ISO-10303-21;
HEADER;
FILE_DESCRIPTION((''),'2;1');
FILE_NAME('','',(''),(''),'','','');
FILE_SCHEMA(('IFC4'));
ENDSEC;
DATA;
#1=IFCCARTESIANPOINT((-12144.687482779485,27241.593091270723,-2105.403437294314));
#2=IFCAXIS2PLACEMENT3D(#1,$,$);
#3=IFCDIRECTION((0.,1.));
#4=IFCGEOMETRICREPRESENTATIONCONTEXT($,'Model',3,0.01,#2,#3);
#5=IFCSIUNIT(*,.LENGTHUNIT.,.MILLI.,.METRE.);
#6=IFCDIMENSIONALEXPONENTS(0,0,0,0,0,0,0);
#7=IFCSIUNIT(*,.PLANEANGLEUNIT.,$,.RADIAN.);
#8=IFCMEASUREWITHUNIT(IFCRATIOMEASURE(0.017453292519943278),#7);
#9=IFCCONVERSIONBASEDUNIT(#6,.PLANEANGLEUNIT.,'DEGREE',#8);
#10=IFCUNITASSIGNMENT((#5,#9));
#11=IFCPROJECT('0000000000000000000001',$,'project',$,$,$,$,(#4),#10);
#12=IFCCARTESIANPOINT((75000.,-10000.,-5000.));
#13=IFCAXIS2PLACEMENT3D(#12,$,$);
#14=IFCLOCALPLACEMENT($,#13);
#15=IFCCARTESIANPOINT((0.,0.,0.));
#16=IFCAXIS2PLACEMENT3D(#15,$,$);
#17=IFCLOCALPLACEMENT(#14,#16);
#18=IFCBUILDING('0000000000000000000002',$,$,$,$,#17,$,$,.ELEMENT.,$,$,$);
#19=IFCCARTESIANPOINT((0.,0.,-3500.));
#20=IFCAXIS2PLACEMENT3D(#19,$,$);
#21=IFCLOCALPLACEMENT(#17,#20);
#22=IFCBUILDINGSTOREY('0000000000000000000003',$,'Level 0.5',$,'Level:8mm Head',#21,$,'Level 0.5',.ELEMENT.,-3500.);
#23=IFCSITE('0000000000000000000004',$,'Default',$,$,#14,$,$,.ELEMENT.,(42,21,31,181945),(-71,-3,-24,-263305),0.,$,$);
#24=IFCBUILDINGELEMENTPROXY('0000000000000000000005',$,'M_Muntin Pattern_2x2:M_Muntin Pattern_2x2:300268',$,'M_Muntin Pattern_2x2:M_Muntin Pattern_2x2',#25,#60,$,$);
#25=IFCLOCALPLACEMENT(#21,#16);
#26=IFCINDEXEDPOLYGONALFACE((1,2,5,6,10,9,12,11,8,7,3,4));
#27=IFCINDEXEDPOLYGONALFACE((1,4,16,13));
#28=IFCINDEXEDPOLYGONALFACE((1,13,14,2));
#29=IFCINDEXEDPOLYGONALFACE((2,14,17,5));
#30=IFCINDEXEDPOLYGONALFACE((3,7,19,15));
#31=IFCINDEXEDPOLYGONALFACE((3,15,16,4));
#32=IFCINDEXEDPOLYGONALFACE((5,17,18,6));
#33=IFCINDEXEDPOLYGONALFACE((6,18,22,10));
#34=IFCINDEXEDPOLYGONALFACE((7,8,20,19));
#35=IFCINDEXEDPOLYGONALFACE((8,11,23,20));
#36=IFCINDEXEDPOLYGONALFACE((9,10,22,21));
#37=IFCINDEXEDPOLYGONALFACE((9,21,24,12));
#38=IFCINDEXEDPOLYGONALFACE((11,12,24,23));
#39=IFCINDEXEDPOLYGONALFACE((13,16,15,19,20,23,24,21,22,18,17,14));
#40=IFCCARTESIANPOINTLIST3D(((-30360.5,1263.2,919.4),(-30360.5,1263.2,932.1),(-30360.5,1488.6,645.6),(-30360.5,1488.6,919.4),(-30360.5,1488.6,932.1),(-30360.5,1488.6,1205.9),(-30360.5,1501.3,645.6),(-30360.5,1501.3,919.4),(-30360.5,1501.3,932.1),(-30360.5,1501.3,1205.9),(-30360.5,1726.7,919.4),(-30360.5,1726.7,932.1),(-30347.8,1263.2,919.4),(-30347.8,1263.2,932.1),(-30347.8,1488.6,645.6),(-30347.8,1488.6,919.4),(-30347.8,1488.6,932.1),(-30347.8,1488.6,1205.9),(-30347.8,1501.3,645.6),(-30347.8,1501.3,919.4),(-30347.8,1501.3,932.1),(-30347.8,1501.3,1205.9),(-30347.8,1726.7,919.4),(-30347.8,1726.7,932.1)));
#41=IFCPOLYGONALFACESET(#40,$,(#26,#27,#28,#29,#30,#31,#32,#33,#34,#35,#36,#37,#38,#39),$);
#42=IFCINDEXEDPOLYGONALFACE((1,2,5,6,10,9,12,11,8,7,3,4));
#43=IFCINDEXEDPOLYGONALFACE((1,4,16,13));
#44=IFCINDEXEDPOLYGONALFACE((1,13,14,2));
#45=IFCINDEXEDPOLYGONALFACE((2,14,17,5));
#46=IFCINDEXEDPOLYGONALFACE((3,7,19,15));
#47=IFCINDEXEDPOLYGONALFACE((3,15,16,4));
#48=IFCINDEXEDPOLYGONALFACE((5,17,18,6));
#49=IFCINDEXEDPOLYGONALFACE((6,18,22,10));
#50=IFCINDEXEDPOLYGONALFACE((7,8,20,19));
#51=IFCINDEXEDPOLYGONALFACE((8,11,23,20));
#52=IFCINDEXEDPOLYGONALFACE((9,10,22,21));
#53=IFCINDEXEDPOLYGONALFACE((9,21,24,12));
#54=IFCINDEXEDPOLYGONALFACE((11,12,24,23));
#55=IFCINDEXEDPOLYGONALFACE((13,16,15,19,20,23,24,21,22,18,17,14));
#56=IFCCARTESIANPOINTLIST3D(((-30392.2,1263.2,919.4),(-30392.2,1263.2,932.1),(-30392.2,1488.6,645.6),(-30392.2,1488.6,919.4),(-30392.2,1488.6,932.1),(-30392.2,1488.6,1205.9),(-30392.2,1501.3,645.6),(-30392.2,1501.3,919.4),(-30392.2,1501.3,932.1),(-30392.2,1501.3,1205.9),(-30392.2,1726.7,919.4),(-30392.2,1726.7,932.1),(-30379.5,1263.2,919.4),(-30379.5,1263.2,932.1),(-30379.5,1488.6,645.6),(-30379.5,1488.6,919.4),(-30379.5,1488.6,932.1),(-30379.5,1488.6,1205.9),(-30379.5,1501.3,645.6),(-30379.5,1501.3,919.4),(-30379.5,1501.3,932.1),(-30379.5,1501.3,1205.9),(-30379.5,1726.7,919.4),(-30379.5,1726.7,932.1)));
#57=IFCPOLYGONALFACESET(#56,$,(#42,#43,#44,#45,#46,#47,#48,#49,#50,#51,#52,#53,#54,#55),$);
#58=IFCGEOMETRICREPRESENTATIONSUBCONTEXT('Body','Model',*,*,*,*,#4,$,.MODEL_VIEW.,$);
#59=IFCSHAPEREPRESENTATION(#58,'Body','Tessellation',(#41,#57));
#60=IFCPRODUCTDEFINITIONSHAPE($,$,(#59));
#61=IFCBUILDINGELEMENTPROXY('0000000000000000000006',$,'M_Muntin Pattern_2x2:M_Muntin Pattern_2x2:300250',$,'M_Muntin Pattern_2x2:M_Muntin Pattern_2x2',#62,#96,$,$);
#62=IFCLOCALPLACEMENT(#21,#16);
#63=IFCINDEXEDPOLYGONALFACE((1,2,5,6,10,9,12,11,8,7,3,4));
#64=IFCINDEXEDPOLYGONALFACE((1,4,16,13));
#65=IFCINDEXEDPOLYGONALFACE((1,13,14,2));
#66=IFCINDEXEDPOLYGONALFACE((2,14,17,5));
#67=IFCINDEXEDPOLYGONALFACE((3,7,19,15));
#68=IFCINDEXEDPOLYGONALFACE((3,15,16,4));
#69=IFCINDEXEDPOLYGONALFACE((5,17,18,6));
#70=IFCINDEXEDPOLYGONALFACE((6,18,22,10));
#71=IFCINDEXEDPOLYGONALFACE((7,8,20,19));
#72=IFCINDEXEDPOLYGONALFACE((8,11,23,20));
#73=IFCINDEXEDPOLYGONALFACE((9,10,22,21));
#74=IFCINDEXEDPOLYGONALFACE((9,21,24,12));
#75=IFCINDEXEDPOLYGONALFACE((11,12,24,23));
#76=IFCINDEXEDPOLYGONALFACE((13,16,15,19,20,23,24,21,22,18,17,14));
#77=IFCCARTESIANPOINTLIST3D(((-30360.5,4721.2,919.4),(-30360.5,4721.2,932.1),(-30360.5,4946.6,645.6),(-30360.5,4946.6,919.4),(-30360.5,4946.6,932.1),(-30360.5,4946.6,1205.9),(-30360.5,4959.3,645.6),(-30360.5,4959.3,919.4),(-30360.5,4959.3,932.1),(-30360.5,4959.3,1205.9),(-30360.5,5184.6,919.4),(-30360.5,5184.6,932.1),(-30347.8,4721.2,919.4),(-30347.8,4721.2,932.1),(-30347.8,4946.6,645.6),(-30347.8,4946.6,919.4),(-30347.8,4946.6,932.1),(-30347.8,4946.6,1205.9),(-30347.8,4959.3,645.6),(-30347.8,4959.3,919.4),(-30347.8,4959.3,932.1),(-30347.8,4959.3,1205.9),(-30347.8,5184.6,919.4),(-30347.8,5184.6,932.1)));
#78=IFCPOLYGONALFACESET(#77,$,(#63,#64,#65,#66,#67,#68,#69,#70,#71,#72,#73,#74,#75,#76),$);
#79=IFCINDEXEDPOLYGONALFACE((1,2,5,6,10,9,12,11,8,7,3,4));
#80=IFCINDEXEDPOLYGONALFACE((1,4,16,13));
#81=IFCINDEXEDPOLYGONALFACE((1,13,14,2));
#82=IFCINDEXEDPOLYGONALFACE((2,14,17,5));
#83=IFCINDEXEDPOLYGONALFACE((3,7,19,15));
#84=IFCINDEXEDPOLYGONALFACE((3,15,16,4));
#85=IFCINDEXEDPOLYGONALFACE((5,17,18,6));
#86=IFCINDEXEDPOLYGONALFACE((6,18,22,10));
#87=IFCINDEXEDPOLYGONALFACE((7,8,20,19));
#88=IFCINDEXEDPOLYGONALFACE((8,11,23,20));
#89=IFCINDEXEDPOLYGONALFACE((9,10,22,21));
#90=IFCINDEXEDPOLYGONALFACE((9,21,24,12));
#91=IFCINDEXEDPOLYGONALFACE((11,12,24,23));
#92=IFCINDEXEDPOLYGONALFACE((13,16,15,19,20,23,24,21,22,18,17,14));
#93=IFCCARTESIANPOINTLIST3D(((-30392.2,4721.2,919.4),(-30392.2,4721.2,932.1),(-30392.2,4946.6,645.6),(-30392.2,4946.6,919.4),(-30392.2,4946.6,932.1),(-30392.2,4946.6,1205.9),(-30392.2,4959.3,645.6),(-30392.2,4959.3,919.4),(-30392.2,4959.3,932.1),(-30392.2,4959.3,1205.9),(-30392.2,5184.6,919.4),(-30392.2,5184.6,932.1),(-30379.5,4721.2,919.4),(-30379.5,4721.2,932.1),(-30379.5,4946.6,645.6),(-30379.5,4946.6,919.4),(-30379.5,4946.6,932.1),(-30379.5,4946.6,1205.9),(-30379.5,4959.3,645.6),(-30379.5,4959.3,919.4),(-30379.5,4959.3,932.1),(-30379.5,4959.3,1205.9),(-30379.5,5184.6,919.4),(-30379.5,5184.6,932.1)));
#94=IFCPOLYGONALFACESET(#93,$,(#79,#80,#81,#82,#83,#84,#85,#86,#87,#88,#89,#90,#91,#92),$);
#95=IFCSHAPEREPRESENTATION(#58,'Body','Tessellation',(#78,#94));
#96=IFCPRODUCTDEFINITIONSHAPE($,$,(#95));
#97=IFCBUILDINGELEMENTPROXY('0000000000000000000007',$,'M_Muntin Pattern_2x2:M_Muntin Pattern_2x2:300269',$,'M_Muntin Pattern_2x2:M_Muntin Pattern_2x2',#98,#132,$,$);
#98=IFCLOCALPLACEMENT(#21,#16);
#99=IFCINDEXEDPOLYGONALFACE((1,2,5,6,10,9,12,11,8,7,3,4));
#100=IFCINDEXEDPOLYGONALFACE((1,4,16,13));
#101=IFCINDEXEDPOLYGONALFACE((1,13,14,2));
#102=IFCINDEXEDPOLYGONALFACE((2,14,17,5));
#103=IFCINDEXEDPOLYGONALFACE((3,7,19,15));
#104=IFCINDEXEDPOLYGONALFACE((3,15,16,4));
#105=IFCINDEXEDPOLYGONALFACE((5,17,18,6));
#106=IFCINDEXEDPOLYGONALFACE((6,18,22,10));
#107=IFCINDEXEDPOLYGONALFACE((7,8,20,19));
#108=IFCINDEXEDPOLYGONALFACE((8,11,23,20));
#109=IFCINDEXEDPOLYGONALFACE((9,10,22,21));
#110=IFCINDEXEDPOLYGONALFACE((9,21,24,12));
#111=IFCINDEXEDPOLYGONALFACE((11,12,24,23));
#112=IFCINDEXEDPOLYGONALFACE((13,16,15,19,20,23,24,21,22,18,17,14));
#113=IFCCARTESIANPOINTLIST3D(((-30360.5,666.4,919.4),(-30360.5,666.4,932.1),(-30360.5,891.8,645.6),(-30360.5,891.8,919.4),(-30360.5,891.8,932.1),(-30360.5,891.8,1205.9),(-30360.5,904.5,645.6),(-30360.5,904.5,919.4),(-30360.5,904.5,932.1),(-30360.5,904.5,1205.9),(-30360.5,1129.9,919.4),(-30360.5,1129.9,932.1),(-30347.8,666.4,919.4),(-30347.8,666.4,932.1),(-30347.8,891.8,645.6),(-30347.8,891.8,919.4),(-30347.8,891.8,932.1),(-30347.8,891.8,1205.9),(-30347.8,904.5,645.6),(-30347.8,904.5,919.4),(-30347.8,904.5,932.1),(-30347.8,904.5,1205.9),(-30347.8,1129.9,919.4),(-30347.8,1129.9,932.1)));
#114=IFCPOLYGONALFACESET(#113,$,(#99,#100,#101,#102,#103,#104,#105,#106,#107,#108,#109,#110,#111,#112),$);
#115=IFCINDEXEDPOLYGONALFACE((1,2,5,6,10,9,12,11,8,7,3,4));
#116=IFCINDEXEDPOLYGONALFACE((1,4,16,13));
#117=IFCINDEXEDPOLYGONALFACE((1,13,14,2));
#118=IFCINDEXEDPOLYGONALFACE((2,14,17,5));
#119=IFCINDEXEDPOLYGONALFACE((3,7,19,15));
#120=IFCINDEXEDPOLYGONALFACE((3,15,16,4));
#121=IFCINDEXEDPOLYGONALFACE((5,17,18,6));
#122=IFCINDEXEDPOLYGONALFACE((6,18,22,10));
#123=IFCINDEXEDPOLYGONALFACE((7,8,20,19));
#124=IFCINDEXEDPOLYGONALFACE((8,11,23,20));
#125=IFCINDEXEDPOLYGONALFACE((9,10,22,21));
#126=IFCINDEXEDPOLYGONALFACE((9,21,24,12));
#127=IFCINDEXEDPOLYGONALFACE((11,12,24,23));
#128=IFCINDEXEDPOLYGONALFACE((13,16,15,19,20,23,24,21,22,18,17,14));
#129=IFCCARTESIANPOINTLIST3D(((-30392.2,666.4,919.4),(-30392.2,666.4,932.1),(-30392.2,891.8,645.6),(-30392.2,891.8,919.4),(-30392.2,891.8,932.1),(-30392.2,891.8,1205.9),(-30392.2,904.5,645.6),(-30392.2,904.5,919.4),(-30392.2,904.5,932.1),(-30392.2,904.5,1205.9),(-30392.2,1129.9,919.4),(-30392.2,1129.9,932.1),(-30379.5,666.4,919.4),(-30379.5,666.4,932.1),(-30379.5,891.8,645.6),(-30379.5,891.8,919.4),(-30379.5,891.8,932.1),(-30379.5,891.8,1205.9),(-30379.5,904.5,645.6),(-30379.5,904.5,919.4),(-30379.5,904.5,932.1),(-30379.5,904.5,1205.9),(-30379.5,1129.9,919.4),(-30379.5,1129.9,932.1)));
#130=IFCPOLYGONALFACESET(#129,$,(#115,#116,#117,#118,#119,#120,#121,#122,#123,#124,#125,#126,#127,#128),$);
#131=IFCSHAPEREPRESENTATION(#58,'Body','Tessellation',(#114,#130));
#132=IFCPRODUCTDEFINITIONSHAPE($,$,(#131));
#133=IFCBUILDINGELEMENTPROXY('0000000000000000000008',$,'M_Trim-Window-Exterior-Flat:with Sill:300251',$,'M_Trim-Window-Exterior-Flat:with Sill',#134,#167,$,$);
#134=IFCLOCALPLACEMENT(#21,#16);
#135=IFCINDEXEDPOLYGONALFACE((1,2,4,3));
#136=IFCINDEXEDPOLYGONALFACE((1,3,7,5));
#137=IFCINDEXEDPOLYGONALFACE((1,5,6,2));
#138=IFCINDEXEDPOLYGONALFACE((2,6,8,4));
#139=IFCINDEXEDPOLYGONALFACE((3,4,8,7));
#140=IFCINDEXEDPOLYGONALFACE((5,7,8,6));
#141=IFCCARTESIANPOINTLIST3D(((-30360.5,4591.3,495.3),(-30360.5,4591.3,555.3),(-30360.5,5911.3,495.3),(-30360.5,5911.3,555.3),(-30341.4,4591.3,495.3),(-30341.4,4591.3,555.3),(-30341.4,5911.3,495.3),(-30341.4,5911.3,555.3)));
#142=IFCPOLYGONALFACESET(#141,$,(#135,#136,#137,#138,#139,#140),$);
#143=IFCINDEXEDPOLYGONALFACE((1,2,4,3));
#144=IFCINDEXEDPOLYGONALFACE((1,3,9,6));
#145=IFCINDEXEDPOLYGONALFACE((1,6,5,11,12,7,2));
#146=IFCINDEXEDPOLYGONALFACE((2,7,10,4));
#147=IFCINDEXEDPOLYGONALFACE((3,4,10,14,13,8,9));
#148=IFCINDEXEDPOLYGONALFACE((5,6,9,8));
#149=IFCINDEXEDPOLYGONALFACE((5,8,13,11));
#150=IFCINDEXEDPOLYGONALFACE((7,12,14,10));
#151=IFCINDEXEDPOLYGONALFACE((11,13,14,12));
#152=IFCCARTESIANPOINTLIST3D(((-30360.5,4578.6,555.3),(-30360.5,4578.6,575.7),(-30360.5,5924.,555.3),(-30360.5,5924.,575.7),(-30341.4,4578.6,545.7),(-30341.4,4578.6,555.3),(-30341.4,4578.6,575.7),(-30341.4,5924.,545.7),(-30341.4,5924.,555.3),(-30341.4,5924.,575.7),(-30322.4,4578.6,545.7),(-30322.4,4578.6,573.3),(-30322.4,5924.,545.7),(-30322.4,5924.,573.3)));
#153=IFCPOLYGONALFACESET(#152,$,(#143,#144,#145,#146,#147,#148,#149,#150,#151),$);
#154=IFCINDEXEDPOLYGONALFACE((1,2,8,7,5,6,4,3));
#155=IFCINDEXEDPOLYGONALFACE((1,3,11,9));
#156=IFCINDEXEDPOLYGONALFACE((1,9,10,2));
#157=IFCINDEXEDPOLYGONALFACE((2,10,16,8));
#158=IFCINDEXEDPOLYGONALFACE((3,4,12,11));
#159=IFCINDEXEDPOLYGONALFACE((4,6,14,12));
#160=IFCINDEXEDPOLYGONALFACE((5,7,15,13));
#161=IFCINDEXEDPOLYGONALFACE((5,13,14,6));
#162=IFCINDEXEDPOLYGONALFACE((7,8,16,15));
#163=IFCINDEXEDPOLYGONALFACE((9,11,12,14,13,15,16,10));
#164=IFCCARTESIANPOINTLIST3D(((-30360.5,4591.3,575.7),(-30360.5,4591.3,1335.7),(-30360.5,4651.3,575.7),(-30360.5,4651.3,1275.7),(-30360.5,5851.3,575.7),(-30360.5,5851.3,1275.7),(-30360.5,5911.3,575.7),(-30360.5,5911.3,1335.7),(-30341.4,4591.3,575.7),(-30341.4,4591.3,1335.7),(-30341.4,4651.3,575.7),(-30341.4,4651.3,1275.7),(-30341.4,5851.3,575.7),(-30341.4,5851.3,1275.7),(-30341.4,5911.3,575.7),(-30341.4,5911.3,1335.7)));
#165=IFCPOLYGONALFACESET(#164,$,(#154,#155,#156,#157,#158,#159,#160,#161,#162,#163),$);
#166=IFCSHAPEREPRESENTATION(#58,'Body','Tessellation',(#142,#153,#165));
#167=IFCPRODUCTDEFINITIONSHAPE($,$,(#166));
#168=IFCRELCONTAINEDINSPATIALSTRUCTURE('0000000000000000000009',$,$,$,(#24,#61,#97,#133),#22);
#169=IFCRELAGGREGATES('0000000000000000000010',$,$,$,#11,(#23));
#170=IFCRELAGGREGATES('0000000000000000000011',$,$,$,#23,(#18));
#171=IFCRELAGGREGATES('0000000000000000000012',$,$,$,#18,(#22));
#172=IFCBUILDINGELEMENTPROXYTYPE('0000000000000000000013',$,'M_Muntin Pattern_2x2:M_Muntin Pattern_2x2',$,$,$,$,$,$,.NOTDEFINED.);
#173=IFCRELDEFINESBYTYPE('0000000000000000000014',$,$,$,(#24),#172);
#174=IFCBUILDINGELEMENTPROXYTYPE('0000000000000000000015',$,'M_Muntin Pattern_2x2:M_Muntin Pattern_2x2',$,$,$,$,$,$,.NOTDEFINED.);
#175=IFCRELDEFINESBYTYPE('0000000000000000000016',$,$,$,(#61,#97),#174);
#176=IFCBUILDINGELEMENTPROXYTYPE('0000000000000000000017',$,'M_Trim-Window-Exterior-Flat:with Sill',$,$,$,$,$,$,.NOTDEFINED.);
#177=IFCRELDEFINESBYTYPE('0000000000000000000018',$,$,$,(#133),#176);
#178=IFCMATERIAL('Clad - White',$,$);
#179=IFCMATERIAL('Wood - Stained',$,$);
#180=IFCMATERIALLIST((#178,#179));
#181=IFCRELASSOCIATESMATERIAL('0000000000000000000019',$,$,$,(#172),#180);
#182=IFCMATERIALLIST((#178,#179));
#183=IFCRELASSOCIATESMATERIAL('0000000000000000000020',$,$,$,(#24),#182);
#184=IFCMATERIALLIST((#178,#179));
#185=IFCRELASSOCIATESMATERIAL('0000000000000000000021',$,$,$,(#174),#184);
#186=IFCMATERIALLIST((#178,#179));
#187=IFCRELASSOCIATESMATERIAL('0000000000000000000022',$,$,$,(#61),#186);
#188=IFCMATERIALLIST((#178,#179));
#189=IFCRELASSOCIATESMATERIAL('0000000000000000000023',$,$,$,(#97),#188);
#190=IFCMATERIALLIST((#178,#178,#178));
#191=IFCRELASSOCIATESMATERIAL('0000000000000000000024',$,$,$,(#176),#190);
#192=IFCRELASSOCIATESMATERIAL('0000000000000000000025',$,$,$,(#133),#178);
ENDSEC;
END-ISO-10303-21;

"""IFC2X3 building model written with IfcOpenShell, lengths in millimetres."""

from ifc_helpers import new_model, entity, si_unit, converted_unit, direction, frame, frame_2d, origin, place, context, subcontext, project, spatial, polyline, rectangle, outline, extrude, source, transform, mapped, material, material_list, type_object, type_shapes, element, save


model = new_model("IFC2X3")

# Units and contexts
model_context = context("Model", 3, precision=0.01, world=frame((-12144.687482779485, 27241.593091270723, -2105.403437294314)), true_north=direction((0.0, 1.0)))
body_context = subcontext(model_context, "Body", "Model", "MODEL_VIEW")
ifc_project = project(units=[si_unit("LENGTHUNIT", "METRE", prefix="MILLI"), converted_unit("PLANEANGLEUNIT", "DEGREE", entity("IfcRatioMeasure", 0.017453292519943278), si_unit("PLANEANGLEUNIT", "RADIAN"), dimensions=[0, 0, 0, 0, 0, 0, 0])], contexts=[model_context])

# Site, building, storey
site_placement = place(None, frame((75000.0, -10000.0, -5000.0)))
site = spatial("IfcSite", under=ifc_project, at=site_placement, Name="Default", CompositionType="ELEMENT", RefLatitude=(42, 21, 31, 181945), RefLongitude=(-71, -3, -24, -263305), RefElevation=0.0)
building_placement = place(site_placement, origin())
building = spatial("IfcBuilding", under=site, at=building_placement, CompositionType="ELEMENT")
storey_placement = place(building_placement, frame((0.0, 0.0, -3500.0)))
storey = spatial("IfcBuildingStorey", under=building, at=storey_placement, Name="Level 0.5", ObjectType="Level:8mm Head", LongName="Level 0.5", CompositionType="ELEMENT", Elevation=-3500.0)

# Building element proxies
ifc_material_1 = material(Name="Clad - White")
ifc_material_2 = material(Name="Wood - Stained")
ifc_material_list_1 = material_list([ifc_material_1, ifc_material_2])
ifc_material_list_2 = material_list([ifc_material_1, ifc_material_2])
building_element_proxy_type_1 = type_object("IfcBuildingElementProxyType", Name="M_Muntin Pattern_2x2:M_Muntin Pattern_2x2", PredefinedType="NOTDEFINED", material=ifc_material_list_2)
shared_shape_1 = source(origin(), body_context, "Body", "SweptSolid", [
    extrude(outline(polyline([(6.4, -6.4), (280.1, -6.4), (280.1, 6.3), (6.4, 6.3), (6.4, 231.7), (-6.3, 231.7), (-6.3, 6.3), (-280.2, 6.3), (-280.2, -6.4), (-6.3, -6.4), (-6.3, -231.7), (6.4, -231.7), (6.4, -6.4)])), frame((0.0, 9.5, 280.1), z_axis=(0.0, 1.0, 0.0), x_axis=(0.0, 0.0, 1.0)), (0.0, 0.0, 1.0), 12.7),
    extrude(outline(polyline([(6.4, -6.4), (280.2, -6.4), (280.2, 6.3), (6.4, 6.3), (6.4, 231.7), (-6.3, 231.7), (-6.3, 6.3), (-280.2, 6.3), (-280.2, -6.4), (-6.3, -6.4), (-6.3, -231.7), (6.4, -231.7), (6.4, -6.4)])), frame((0.0, -22.2, 280.2), z_axis=(0.0, 1.0, 0.0), x_axis=(0.0, 0.0, 1.0)), (0.0, 0.0, 1.0), 12.7),
])
type_shapes(building_element_proxy_type_1, [shared_shape_1])
proxy_1_placement = place(storey_placement, frame((-30370.0, 1495.0, 645.6), z_axis=(0.0, 0.0, 1.0), x_axis=(0.0, -1.0, 0.0)))
element("IfcBuildingElementProxy", 1, at=proxy_1_placement, inside=storey, type_object=building_element_proxy_type_1, material=ifc_material_list_1, Name="M_Muntin Pattern_2x2:M_Muntin Pattern_2x2:300268", ObjectType="M_Muntin Pattern_2x2:M_Muntin Pattern_2x2", context=body_context, shape_type="MappedRepresentation", body=[
    mapped(shared_shape_1, transform((0.0, 0.0, 0.0), scale=1.0)),
])
ifc_material_list_3 = material_list([ifc_material_1, ifc_material_2])
ifc_material_list_4 = material_list([ifc_material_1, ifc_material_2])
building_element_proxy_type_2 = type_object("IfcBuildingElementProxyType", Name="M_Muntin Pattern_2x2:M_Muntin Pattern_2x2", PredefinedType="NOTDEFINED", material=ifc_material_list_4)
shared_shape_2 = source(origin(), body_context, "Body", "SweptSolid", [
    extrude(outline(polyline([(6.4, -6.4), (280.1, -6.4), (280.1, 6.3), (6.4, 6.3), (6.4, 231.7), (-6.3, 231.7), (-6.3, 6.3), (-280.2, 6.3), (-280.2, -6.4), (-6.3, -6.4), (-6.3, -231.7), (6.4, -231.7), (6.4, -6.4)])), frame((0.0, -22.2, 280.1), z_axis=(0.0, 1.0, 0.0), x_axis=(0.0, 0.0, 1.0)), (0.0, 0.0, 1.0), 12.7),
    extrude(outline(polyline([(6.4, -6.4), (280.2, -6.4), (280.2, 6.3), (6.4, 6.3), (6.4, 231.7), (-6.3, 231.7), (-6.3, 6.3), (-280.2, 6.3), (-280.2, -6.4), (-6.3, -6.4), (-6.3, -231.7), (6.4, -231.7), (6.4, -6.4)])), frame((0.0, 9.5, 280.2), z_axis=(0.0, 1.0, 0.0), x_axis=(0.0, 0.0, 1.0)), (0.0, 0.0, 1.0), 12.7),
])
type_shapes(building_element_proxy_type_2, [shared_shape_2])
proxy_2_placement = place(storey_placement, frame((-30370.0, 4952.9, 645.6), z_axis=(0.0, 0.0, 1.0), x_axis=(0.0, 1.0, 0.0)))
element("IfcBuildingElementProxy", 2, at=proxy_2_placement, inside=storey, type_object=building_element_proxy_type_2, material=ifc_material_list_3, Name="M_Muntin Pattern_2x2:M_Muntin Pattern_2x2:300250", ObjectType="M_Muntin Pattern_2x2:M_Muntin Pattern_2x2", context=body_context, shape_type="MappedRepresentation", body=[
    mapped(shared_shape_2, transform((0.0, 0.0, 0.0), scale=1.0)),
])
ifc_material_list_5 = material_list([ifc_material_1, ifc_material_2])
proxy_3_placement = place(storey_placement, frame((-30370.0, 898.1, 645.6), z_axis=(0.0, 0.0, 1.0), x_axis=(0.0, 1.0, 0.0)))
element("IfcBuildingElementProxy", 3, at=proxy_3_placement, inside=storey, type_object=building_element_proxy_type_2, material=ifc_material_list_5, Name="M_Muntin Pattern_2x2:M_Muntin Pattern_2x2:300269", ObjectType="M_Muntin Pattern_2x2:M_Muntin Pattern_2x2", context=body_context, shape_type="MappedRepresentation", body=[
    mapped(shared_shape_2, transform((0.0, 0.0, 0.0), scale=1.0)),
])
ifc_material_list_6 = material_list([ifc_material_1, ifc_material_1, ifc_material_1])
building_element_proxy_type_3 = type_object("IfcBuildingElementProxyType", Name="M_Trim-Window-Exterior-Flat:with Sill", PredefinedType="NOTDEFINED", material=ifc_material_list_6)
shared_shape_3 = source(origin(), body_context, "Body", "SweptSolid", [
    extrude(rectangle(XDim=1320.0, YDim=60.0, at=frame_2d((0.0, 0.0), x_axis=(1.0, 0.0))), frame((0.0, -750.4, 0.0), z_axis=(0.0, 0.0, 1.0), x_axis=(-1.0, 0.0, 0.0)), (0.0, 0.0, 1.0), 19.0),
    extrude(outline(polyline([(-19.0, -15.2), (0.0, -15.2), (0.0, -5.7), (19.0, -5.7), (19.0, 14.8), (0.0, 14.8), (-19.0, 12.3), (-19.0, -15.2)])), frame((-672.7, -714.8, 19.0), z_axis=(1.0, 0.0, 0.0), x_axis=(0.0, 0.0, -1.0)), (0.0, 0.0, 1.0), 1345.4),
    extrude(outline(polyline([(-395.0, -660.0), (365.0, -660.0), (365.0, -600.0), (-335.0, -600.0), (-335.0, 600.0), (365.0, 600.0), (365.0, 660.0), (-395.0, 660.0), (-395.0, -660.0)])), frame((0.0, -335.0, 0.0), z_axis=(0.0, 0.0, 1.0), x_axis=(0.0, -1.0, 0.0)), (0.0, 0.0, 1.0), 19.0),
])
type_shapes(building_element_proxy_type_3, [shared_shape_3])
for number, where, z_axis, x_axis, name in (
    (4, (-30360.5, 5251.3, 1275.7), (1.0, 0.0, 0.0), (0.0, 1.0, 0.0), "M_Trim-Window-Exterior-Flat:with Sill:300251"),
):
    element("IfcBuildingElementProxy", number, at=place(storey_placement, frame(where, z_axis=z_axis, x_axis=x_axis)), inside=storey, type_object=building_element_proxy_type_3, material=ifc_material_1, Name=name, ObjectType="M_Trim-Window-Exterior-Flat:with Sill", context=body_context, shape_type="MappedRepresentation", body=[
        mapped(shared_shape_3, transform((0.0, 0.0, 0.0), scale=1.0)),
    ])

save(model, "model.ifc")
